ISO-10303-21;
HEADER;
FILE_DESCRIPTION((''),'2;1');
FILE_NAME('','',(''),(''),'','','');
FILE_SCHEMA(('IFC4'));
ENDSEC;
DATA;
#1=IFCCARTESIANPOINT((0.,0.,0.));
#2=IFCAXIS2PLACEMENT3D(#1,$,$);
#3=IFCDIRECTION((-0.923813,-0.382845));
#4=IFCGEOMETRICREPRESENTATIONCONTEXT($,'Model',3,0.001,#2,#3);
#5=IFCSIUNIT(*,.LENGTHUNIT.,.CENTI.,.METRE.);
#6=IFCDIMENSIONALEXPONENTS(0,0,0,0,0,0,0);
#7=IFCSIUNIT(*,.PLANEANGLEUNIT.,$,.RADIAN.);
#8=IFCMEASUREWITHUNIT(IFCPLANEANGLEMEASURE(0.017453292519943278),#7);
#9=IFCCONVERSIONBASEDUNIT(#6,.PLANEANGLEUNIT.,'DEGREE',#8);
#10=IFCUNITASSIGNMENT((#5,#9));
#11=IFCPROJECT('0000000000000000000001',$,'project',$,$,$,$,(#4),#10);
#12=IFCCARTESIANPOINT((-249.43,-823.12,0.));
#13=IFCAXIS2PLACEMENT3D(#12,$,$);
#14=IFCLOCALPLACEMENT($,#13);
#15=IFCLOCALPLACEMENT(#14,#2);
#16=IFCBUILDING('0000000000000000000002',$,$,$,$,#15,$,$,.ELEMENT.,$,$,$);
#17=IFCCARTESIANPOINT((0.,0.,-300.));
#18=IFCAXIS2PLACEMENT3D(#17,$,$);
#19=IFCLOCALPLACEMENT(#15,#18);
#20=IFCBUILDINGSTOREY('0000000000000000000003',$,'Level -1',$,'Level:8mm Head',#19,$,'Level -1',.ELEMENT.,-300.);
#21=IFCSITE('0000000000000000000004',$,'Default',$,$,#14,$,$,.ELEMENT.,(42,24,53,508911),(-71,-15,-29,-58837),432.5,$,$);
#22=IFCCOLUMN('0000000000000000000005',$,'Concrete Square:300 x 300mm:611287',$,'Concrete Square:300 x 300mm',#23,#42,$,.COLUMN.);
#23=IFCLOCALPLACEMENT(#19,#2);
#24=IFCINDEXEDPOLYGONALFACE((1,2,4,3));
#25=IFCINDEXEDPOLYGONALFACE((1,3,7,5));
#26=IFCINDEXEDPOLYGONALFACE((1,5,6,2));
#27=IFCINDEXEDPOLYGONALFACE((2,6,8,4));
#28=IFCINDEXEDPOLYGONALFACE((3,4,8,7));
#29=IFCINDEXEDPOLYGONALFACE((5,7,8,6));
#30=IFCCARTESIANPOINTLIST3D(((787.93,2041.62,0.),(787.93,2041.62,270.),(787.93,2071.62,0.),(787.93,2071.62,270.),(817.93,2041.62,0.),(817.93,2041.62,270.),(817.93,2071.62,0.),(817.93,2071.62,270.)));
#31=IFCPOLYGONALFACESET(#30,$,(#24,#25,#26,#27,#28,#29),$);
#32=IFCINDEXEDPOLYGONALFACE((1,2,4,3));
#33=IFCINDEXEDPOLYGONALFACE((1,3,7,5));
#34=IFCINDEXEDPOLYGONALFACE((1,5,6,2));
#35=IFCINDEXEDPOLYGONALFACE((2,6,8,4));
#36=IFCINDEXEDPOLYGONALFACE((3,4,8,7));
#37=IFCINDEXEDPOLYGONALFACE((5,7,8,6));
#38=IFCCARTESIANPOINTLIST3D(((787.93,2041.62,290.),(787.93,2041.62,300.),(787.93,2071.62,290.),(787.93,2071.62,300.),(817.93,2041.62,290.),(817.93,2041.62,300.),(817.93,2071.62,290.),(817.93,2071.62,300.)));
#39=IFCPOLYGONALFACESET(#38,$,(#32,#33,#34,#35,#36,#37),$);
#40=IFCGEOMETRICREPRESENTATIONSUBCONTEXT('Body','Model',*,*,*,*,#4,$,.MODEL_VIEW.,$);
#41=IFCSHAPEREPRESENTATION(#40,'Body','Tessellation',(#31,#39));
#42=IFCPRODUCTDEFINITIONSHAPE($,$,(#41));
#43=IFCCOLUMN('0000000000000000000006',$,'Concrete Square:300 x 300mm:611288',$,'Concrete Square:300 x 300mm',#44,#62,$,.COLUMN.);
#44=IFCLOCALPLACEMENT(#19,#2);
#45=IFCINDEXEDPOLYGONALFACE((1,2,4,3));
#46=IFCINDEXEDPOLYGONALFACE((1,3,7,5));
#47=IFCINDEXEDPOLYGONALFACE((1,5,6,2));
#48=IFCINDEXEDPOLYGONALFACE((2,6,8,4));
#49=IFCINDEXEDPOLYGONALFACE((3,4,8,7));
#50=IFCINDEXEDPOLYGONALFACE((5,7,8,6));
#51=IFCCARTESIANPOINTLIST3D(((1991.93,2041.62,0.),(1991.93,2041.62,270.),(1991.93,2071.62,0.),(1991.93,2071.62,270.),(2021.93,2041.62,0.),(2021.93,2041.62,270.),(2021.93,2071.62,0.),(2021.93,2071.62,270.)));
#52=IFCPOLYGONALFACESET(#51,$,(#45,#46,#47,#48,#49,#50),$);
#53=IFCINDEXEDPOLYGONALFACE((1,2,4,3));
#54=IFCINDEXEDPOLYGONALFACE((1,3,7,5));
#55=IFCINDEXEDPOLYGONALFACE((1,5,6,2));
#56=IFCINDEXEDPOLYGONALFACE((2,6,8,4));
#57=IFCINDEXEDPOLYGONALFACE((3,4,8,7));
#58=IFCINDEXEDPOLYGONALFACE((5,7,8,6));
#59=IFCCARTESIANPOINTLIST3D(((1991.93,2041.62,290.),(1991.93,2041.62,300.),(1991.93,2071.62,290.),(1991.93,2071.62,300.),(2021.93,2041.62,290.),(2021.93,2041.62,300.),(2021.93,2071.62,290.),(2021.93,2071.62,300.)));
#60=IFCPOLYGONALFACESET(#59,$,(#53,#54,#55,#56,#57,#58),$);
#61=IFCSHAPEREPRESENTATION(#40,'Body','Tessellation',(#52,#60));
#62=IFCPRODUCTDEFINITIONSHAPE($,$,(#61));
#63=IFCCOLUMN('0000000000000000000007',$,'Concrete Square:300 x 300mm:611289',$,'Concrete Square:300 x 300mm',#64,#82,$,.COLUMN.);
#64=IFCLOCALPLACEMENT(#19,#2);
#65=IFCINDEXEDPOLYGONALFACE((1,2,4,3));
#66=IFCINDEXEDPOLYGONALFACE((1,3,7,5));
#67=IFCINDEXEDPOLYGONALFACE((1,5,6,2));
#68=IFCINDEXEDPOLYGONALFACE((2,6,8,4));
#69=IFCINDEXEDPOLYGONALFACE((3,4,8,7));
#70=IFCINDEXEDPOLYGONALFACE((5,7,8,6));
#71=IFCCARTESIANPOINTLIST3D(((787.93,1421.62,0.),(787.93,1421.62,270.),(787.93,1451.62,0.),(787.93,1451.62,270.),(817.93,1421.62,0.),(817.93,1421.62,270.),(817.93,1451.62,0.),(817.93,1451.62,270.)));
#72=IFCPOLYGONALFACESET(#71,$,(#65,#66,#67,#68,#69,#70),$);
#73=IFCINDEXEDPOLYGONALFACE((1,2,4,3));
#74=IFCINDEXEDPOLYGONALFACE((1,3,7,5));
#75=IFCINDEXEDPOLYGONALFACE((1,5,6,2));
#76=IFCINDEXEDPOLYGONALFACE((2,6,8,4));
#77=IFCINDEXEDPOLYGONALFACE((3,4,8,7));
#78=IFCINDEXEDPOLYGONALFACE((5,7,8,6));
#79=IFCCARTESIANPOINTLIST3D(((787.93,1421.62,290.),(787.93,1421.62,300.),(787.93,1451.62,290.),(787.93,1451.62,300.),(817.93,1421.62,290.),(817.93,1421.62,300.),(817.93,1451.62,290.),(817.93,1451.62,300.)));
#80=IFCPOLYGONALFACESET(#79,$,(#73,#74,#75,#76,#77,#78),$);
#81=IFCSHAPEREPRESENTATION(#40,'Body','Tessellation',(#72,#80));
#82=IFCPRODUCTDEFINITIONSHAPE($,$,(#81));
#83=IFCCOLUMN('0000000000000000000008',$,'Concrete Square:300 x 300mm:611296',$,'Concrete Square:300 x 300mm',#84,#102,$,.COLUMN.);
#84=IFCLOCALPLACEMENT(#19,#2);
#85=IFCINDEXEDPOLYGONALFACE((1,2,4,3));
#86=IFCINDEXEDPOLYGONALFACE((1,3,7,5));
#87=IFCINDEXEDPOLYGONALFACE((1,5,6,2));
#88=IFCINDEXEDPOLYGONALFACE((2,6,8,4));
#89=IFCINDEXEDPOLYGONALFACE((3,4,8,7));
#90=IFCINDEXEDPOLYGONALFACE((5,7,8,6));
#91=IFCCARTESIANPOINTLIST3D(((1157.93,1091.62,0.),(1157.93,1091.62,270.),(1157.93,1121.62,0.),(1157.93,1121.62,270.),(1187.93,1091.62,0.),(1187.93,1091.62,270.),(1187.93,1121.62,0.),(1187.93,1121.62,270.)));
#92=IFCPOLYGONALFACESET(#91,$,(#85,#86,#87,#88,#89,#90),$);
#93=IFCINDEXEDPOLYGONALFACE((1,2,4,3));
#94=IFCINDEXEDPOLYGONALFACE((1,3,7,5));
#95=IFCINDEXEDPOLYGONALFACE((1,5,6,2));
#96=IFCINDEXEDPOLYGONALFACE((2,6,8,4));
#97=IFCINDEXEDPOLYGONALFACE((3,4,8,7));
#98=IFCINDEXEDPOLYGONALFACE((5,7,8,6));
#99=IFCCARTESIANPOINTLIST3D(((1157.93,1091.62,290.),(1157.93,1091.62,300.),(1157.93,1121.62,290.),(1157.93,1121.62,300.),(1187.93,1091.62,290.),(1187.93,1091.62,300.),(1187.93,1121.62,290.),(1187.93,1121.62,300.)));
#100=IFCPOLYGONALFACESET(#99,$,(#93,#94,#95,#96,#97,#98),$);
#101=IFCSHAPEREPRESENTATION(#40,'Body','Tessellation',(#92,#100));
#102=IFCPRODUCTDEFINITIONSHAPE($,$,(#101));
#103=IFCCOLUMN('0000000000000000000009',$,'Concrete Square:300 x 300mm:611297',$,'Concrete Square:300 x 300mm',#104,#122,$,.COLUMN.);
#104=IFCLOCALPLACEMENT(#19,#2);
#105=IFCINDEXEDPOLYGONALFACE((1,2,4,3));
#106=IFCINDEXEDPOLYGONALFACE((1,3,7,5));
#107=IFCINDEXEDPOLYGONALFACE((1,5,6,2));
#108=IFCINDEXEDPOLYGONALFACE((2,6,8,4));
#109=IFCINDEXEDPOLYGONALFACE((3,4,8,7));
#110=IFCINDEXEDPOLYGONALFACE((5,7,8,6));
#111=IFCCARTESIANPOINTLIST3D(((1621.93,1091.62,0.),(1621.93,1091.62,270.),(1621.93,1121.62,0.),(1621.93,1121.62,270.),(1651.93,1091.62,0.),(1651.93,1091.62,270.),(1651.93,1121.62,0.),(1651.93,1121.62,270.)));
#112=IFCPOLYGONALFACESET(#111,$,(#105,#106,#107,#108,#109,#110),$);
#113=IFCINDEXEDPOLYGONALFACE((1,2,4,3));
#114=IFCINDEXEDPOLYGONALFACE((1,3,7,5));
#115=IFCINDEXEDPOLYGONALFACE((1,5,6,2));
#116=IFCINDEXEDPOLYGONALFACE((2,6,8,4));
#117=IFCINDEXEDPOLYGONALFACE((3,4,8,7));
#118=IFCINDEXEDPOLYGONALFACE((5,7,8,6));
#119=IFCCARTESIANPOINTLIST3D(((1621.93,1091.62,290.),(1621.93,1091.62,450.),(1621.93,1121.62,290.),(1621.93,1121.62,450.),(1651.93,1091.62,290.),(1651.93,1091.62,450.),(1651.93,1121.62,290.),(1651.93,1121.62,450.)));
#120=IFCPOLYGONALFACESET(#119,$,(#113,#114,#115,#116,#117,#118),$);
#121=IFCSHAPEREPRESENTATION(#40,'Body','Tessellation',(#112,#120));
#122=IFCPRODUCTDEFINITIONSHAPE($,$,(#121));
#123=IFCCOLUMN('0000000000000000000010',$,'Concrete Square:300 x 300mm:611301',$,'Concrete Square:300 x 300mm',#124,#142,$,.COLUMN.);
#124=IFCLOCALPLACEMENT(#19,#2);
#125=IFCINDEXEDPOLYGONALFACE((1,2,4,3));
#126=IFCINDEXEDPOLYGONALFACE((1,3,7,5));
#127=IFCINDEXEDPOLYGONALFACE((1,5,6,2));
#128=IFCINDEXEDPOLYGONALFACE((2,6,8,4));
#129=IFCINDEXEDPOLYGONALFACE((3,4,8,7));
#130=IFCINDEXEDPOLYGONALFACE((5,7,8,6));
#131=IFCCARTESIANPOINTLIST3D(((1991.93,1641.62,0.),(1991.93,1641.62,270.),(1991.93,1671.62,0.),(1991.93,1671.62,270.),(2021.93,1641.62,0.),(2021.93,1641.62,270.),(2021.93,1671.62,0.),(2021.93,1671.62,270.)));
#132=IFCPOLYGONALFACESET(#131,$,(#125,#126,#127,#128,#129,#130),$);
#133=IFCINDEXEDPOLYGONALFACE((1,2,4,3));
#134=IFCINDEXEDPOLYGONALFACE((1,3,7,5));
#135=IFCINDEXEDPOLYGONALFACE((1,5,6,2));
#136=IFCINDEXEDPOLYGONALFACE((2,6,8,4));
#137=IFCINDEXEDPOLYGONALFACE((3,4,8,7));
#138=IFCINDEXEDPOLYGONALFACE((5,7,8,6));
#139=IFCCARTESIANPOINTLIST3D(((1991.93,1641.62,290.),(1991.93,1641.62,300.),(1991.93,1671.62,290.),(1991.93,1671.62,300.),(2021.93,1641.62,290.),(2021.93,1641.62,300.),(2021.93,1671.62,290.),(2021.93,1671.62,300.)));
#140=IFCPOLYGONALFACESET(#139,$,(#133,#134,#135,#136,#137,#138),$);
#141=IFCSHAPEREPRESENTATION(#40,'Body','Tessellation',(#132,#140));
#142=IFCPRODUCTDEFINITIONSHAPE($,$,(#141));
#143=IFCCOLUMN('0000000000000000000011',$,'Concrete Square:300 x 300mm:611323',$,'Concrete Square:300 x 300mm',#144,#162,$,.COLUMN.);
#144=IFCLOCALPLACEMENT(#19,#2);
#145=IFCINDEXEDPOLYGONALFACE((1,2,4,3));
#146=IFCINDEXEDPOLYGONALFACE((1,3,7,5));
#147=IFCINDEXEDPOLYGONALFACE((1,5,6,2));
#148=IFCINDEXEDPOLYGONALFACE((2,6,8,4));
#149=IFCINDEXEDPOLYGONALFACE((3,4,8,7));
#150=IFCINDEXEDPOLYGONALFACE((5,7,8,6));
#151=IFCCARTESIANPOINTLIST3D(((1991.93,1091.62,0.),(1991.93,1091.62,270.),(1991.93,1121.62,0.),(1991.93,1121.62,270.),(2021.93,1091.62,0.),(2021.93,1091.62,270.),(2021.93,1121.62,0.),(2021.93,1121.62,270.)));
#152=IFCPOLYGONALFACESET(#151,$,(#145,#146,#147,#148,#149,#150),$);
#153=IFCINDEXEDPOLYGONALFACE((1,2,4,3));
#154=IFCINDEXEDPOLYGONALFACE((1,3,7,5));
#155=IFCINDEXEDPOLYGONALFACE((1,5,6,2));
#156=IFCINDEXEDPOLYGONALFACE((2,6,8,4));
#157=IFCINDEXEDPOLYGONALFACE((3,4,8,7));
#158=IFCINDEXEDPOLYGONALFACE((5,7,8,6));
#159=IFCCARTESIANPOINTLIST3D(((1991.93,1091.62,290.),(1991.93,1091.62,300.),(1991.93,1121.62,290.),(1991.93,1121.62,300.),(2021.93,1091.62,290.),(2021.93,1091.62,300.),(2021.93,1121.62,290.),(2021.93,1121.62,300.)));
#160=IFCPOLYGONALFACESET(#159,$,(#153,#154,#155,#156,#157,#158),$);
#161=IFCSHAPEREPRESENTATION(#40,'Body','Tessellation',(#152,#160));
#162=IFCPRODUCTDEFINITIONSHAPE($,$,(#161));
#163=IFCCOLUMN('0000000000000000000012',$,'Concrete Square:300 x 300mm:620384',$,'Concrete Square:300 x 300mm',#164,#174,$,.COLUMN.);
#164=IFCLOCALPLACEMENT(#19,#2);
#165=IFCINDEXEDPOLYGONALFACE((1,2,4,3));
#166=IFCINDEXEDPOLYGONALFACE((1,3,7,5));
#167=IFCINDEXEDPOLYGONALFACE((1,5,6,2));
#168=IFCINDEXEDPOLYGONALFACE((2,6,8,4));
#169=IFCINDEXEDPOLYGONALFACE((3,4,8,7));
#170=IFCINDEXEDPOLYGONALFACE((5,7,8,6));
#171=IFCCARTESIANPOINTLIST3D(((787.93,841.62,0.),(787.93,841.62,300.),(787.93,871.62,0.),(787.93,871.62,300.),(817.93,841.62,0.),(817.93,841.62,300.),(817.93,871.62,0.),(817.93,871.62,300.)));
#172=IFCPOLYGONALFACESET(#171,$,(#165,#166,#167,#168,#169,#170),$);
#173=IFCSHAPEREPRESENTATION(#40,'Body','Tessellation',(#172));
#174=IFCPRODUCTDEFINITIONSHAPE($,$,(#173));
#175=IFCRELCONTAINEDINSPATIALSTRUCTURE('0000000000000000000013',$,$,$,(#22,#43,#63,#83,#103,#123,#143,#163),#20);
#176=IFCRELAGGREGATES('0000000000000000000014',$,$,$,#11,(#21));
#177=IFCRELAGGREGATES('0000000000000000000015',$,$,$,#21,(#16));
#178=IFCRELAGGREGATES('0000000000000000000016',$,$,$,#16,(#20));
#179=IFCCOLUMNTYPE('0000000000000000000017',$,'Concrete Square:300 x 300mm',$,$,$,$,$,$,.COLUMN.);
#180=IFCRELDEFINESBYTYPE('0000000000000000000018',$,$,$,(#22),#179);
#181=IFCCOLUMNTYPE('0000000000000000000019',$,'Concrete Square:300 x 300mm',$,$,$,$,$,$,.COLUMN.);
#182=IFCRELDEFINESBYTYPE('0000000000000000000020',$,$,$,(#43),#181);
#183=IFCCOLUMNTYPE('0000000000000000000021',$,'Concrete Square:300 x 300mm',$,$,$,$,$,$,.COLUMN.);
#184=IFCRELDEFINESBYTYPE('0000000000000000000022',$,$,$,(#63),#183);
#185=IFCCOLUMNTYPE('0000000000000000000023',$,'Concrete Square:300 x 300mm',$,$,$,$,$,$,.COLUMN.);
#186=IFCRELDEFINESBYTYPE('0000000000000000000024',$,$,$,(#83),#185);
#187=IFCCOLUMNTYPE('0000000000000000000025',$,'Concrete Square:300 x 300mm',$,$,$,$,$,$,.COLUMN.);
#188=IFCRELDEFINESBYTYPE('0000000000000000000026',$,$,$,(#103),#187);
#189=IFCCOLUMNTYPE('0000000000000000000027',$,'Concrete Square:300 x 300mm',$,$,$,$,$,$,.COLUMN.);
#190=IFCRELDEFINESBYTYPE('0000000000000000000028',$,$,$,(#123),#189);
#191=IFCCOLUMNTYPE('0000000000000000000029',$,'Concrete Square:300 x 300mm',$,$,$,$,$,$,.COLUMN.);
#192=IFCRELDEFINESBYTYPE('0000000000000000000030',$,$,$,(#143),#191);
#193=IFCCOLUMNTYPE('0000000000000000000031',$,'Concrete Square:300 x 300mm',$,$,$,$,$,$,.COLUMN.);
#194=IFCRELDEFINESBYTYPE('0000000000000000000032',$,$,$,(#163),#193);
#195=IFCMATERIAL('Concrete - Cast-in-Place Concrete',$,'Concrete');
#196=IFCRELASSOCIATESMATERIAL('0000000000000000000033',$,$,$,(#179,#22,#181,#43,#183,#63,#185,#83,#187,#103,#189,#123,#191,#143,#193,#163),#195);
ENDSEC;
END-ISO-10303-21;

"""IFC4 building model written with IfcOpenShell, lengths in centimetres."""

from ifc_helpers import new_model, entity, si_unit, converted_unit, direction, frame, origin, place, context, subcontext, project, spatial, indexed_curve, outline, extrude, source, transform, mapped, material, type_object, type_shapes, element, save


model = new_model("IFC4")

# Units and contexts
model_context = context("Model", 3, precision=0.001, world=origin(), true_north=direction((-0.923813, -0.382845)))
body_context = subcontext(model_context, "Body", "Model", "MODEL_VIEW")
ifc_project = project(units=[si_unit("LENGTHUNIT", "METRE", prefix="CENTI"), converted_unit("PLANEANGLEUNIT", "DEGREE", entity("IfcPlaneAngleMeasure", 0.017453292519943278), si_unit("PLANEANGLEUNIT", "RADIAN"), dimensions=[0, 0, 0, 0, 0, 0, 0])], contexts=[model_context])

# Site, building, storey
site_placement = place(None, frame((-249.43, -823.12, 0.0)))
site = spatial("IfcSite", under=ifc_project, at=site_placement, Name="Default", CompositionType="ELEMENT", RefLatitude=(42, 24, 53, 508911), RefLongitude=(-71, -15, -29, -58837), RefElevation=432.5)
building_placement = place(site_placement, origin())
building = spatial("IfcBuilding", under=site, at=building_placement, CompositionType="ELEMENT")
storey_placement = place(building_placement, frame((0.0, 0.0, -300.0)))
storey = spatial("IfcBuildingStorey", under=building, at=storey_placement, Name="Level -1", ObjectType="Level:8mm Head", LongName="Level -1", CompositionType="ELEMENT", Elevation=-300.0)

# Columns
ifc_material_1 = material(Name="Concrete - Cast-in-Place Concrete", Category="Concrete")
column_type_1 = type_object("IfcColumnType", Name="Concrete Square:300 x 300mm", PredefinedType="COLUMN", material=ifc_material_1)
shared_shape_1 = source(origin(), body_context, "Body", "SweptSolid", [
    extrude(outline(indexed_curve([(-15.0, -15.0), (15.0, -15.0), (15.0, 15.0), (-15.0, 15.0), (-15.0, -15.0)], self_intersect=False)), frame((802.93, 2056.62, -300.0), z_axis=(0.0, 0.0, 1.0), x_axis=(-1.0, 0.0, 0.0)), (0.0, 0.0, 1.0), 270.0),
    extrude(outline(indexed_curve([(-15.0, -15.0), (15.0, -15.0), (15.0, 15.0), (-15.0, 15.0), (-15.0, -15.0)], self_intersect=False)), frame((802.93, 2056.62, -10.0), z_axis=(0.0, 0.0, 1.0), x_axis=(-1.0, 0.0, 0.0)), (0.0, 0.0, 1.0), 10.0),
])
type_shapes(column_type_1, [shared_shape_1])
column_1_placement = place(storey_placement, frame((0.0, 0.0, 300.0)))
element("IfcColumn", 1, at=column_1_placement, inside=storey, type_object=column_type_1, material=ifc_material_1, Name="Concrete Square:300 x 300mm:611287", ObjectType="Concrete Square:300 x 300mm", PredefinedType="COLUMN", context=body_context, shape_type="MappedRepresentation", body=[
    mapped(shared_shape_1, transform((0.0, 0.0, 0.0), scale=1.0)),
])
column_type_2 = type_object("IfcColumnType", Name="Concrete Square:300 x 300mm", PredefinedType="COLUMN", material=ifc_material_1)
shared_shape_2 = source(origin(), body_context, "Body", "SweptSolid", [
    extrude(outline(indexed_curve([(-15.0, -15.0), (15.0, -15.0), (15.0, 15.0), (-15.0, 15.0), (-15.0, -15.0)], self_intersect=False)), frame((2006.93, 2056.62, -300.0), z_axis=(0.0, 0.0, 1.0), x_axis=(-1.0, 0.0, 0.0)), (0.0, 0.0, 1.0), 270.0),
    extrude(outline(indexed_curve([(-15.0, -15.0), (15.0, -15.0), (15.0, 15.0), (-15.0, 15.0), (-15.0, -15.0)], self_intersect=False)), frame((2006.93, 2056.62, -10.0), z_axis=(0.0, 0.0, 1.0), x_axis=(-1.0, 0.0, 0.0)), (0.0, 0.0, 1.0), 10.0),
])
type_shapes(column_type_2, [shared_shape_2])
column_2_placement = place(storey_placement, frame((0.0, 0.0, 300.0)))
element("IfcColumn", 2, at=column_2_placement, inside=storey, type_object=column_type_2, material=ifc_material_1, Name="Concrete Square:300 x 300mm:611288", ObjectType="Concrete Square:300 x 300mm", PredefinedType="COLUMN", context=body_context, shape_type="MappedRepresentation", body=[
    mapped(shared_shape_2, transform((0.0, 0.0, 0.0), scale=1.0)),
])
column_type_3 = type_object("IfcColumnType", Name="Concrete Square:300 x 300mm", PredefinedType="COLUMN", material=ifc_material_1)
shared_shape_3 = source(origin(), body_context, "Body", "SweptSolid", [
    extrude(outline(indexed_curve([(-15.0, -15.0), (15.0, -15.0), (15.0, 15.0), (-15.0, 15.0), (-15.0, -15.0)], self_intersect=False)), frame((802.93, 1436.62, -300.0), z_axis=(0.0, 0.0, 1.0), x_axis=(-1.0, 0.0, 0.0)), (0.0, 0.0, 1.0), 270.0),
    extrude(outline(indexed_curve([(-15.0, -15.0), (15.0, -15.0), (15.0, 15.0), (-15.0, 15.0), (-15.0, -15.0)], self_intersect=False)), frame((802.93, 1436.62, -10.0), z_axis=(0.0, 0.0, 1.0), x_axis=(-1.0, 0.0, 0.0)), (0.0, 0.0, 1.0), 10.0),
])
type_shapes(column_type_3, [shared_shape_3])
column_3_placement = place(storey_placement, frame((0.0, 0.0, 300.0)))
element("IfcColumn", 3, at=column_3_placement, inside=storey, type_object=column_type_3, material=ifc_material_1, Name="Concrete Square:300 x 300mm:611289", ObjectType="Concrete Square:300 x 300mm", PredefinedType="COLUMN", context=body_context, shape_type="MappedRepresentation", body=[
    mapped(shared_shape_3, transform((0.0, 0.0, 0.0), scale=1.0)),
])
column_type_4 = type_object("IfcColumnType", Name="Concrete Square:300 x 300mm", PredefinedType="COLUMN", material=ifc_material_1)
shared_shape_4 = source(origin(), body_context, "Body", "SweptSolid", [
    extrude(outline(indexed_curve([(-15.0, -15.0), (15.0, -15.0), (15.0, 15.0), (-15.0, 15.0), (-15.0, -15.0)], self_intersect=False)), frame((1172.93, 1106.62, -300.0), z_axis=(0.0, 0.0, 1.0), x_axis=(-1.0, 0.0, 0.0)), (0.0, 0.0, 1.0), 270.0),
    extrude(outline(indexed_curve([(-15.0, -15.0), (15.0, -15.0), (15.0, 15.0), (-15.0, 15.0), (-15.0, -15.0)], self_intersect=False)), frame((1172.93, 1106.62, -10.0), z_axis=(0.0, 0.0, 1.0), x_axis=(-1.0, 0.0, 0.0)), (0.0, 0.0, 1.0), 10.0),
])
type_shapes(column_type_4, [shared_shape_4])
column_4_placement = place(storey_placement, frame((0.0, 0.0, 300.0)))
element("IfcColumn", 4, at=column_4_placement, inside=storey, type_object=column_type_4, material=ifc_material_1, Name="Concrete Square:300 x 300mm:611296", ObjectType="Concrete Square:300 x 300mm", PredefinedType="COLUMN", context=body_context, shape_type="MappedRepresentation", body=[
    mapped(shared_shape_4, transform((0.0, 0.0, 0.0), scale=1.0)),
])
column_type_5 = type_object("IfcColumnType", Name="Concrete Square:300 x 300mm", PredefinedType="COLUMN", material=ifc_material_1)
shared_shape_5 = source(origin(), body_context, "Body", "SweptSolid", [
    extrude(outline(indexed_curve([(-15.0, -15.0), (15.0, -15.0), (15.0, 15.0), (-15.0, 15.0), (-15.0, -15.0)], self_intersect=False)), frame((1636.93, 1106.62, -300.0), z_axis=(0.0, 0.0, 1.0), x_axis=(-1.0, 0.0, 0.0)), (0.0, 0.0, 1.0), 270.0),
    extrude(outline(indexed_curve([(-15.0, -15.0), (15.0, -15.0), (15.0, 15.0), (-15.0, 15.0), (-15.0, -15.0)], self_intersect=False)), frame((1636.93, 1106.62, -10.0), z_axis=(0.0, 0.0, 1.0), x_axis=(-1.0, 0.0, 0.0)), (0.0, 0.0, 1.0), 160.0),
])
type_shapes(column_type_5, [shared_shape_5])
column_5_placement = place(storey_placement, frame((0.0, 0.0, 300.0)))
element("IfcColumn", 5, at=column_5_placement, inside=storey, type_object=column_type_5, material=ifc_material_1, Name="Concrete Square:300 x 300mm:611297", ObjectType="Concrete Square:300 x 300mm", PredefinedType="COLUMN", context=body_context, shape_type="MappedRepresentation", body=[
    mapped(shared_shape_5, transform((0.0, 0.0, 0.0), scale=1.0)),
])
column_type_6 = type_object("IfcColumnType", Name="Concrete Square:300 x 300mm", PredefinedType="COLUMN", material=ifc_material_1)
shared_shape_6 = source(origin(), body_context, "Body", "SweptSolid", [
    extrude(outline(indexed_curve([(-15.0, -15.0), (15.0, -15.0), (15.0, 15.0), (-15.0, 15.0), (-15.0, -15.0)], self_intersect=False)), frame((2006.93, 1656.62, -300.0), z_axis=(0.0, 0.0, 1.0), x_axis=(-1.0, 0.0, 0.0)), (0.0, 0.0, 1.0), 270.0),
    extrude(outline(indexed_curve([(-15.0, -15.0), (15.0, -15.0), (15.0, 15.0), (-15.0, 15.0), (-15.0, -15.0)], self_intersect=False)), frame((2006.93, 1656.62, -10.0), z_axis=(0.0, 0.0, 1.0), x_axis=(-1.0, 0.0, 0.0)), (0.0, 0.0, 1.0), 10.0),
])
type_shapes(column_type_6, [shared_shape_6])
column_6_placement = place(storey_placement, frame((0.0, 0.0, 300.0)))
element("IfcColumn", 6, at=column_6_placement, inside=storey, type_object=column_type_6, material=ifc_material_1, Name="Concrete Square:300 x 300mm:611301", ObjectType="Concrete Square:300 x 300mm", PredefinedType="COLUMN", context=body_context, shape_type="MappedRepresentation", body=[
    mapped(shared_shape_6, transform((0.0, 0.0, 0.0), scale=1.0)),
])
column_type_7 = type_object("IfcColumnType", Name="Concrete Square:300 x 300mm", PredefinedType="COLUMN", material=ifc_material_1)
shared_shape_7 = source(origin(), body_context, "Body", "SweptSolid", [
    extrude(outline(indexed_curve([(-15.0, -15.0), (15.0, -15.0), (15.0, 15.0), (-15.0, 15.0), (-15.0, -15.0)], self_intersect=False)), frame((2006.93, 1106.62, -300.0), z_axis=(0.0, 0.0, 1.0), x_axis=(-1.0, 0.0, 0.0)), (0.0, 0.0, 1.0), 270.0),
    extrude(outline(indexed_curve([(-15.0, -15.0), (15.0, -15.0), (15.0, 15.0), (-15.0, 15.0), (-15.0, -15.0)], self_intersect=False)), frame((2006.93, 1106.62, -10.0), z_axis=(0.0, 0.0, 1.0), x_axis=(-1.0, 0.0, 0.0)), (0.0, 0.0, 1.0), 10.0),
])
type_shapes(column_type_7, [shared_shape_7])
column_7_placement = place(storey_placement, frame((0.0, 0.0, 300.0)))
element("IfcColumn", 7, at=column_7_placement, inside=storey, type_object=column_type_7, material=ifc_material_1, Name="Concrete Square:300 x 300mm:611323", ObjectType="Concrete Square:300 x 300mm", PredefinedType="COLUMN", context=body_context, shape_type="MappedRepresentation", body=[
    mapped(shared_shape_7, transform((0.0, 0.0, 0.0), scale=1.0)),
])
column_type_8 = type_object("IfcColumnType", Name="Concrete Square:300 x 300mm", PredefinedType="COLUMN", material=ifc_material_1)
shared_shape_8 = source(origin(), body_context, "Body", "SweptSolid", [
    extrude(outline(indexed_curve([(-15.0, -15.0), (15.0, -15.0), (15.0, 15.0), (-15.0, 15.0), (-15.0, -15.0)], self_intersect=False)), frame((802.93, 856.62, -300.0), z_axis=(0.0, 0.0, 1.0), x_axis=(-1.0, 0.0, 0.0)), (0.0, 0.0, 1.0), 300.0),
])
type_shapes(column_type_8, [shared_shape_8])
column_8_placement = place(storey_placement, frame((0.0, 0.0, 300.0)))
element("IfcColumn", 8, at=column_8_placement, inside=storey, type_object=column_type_8, material=ifc_material_1, Name="Concrete Square:300 x 300mm:620384", ObjectType="Concrete Square:300 x 300mm", PredefinedType="COLUMN", context=body_context, shape_type="MappedRepresentation", body=[
    mapped(shared_shape_8, transform((0.0, 0.0, 0.0), scale=1.0)),
])

save(model, "model.ifc")
